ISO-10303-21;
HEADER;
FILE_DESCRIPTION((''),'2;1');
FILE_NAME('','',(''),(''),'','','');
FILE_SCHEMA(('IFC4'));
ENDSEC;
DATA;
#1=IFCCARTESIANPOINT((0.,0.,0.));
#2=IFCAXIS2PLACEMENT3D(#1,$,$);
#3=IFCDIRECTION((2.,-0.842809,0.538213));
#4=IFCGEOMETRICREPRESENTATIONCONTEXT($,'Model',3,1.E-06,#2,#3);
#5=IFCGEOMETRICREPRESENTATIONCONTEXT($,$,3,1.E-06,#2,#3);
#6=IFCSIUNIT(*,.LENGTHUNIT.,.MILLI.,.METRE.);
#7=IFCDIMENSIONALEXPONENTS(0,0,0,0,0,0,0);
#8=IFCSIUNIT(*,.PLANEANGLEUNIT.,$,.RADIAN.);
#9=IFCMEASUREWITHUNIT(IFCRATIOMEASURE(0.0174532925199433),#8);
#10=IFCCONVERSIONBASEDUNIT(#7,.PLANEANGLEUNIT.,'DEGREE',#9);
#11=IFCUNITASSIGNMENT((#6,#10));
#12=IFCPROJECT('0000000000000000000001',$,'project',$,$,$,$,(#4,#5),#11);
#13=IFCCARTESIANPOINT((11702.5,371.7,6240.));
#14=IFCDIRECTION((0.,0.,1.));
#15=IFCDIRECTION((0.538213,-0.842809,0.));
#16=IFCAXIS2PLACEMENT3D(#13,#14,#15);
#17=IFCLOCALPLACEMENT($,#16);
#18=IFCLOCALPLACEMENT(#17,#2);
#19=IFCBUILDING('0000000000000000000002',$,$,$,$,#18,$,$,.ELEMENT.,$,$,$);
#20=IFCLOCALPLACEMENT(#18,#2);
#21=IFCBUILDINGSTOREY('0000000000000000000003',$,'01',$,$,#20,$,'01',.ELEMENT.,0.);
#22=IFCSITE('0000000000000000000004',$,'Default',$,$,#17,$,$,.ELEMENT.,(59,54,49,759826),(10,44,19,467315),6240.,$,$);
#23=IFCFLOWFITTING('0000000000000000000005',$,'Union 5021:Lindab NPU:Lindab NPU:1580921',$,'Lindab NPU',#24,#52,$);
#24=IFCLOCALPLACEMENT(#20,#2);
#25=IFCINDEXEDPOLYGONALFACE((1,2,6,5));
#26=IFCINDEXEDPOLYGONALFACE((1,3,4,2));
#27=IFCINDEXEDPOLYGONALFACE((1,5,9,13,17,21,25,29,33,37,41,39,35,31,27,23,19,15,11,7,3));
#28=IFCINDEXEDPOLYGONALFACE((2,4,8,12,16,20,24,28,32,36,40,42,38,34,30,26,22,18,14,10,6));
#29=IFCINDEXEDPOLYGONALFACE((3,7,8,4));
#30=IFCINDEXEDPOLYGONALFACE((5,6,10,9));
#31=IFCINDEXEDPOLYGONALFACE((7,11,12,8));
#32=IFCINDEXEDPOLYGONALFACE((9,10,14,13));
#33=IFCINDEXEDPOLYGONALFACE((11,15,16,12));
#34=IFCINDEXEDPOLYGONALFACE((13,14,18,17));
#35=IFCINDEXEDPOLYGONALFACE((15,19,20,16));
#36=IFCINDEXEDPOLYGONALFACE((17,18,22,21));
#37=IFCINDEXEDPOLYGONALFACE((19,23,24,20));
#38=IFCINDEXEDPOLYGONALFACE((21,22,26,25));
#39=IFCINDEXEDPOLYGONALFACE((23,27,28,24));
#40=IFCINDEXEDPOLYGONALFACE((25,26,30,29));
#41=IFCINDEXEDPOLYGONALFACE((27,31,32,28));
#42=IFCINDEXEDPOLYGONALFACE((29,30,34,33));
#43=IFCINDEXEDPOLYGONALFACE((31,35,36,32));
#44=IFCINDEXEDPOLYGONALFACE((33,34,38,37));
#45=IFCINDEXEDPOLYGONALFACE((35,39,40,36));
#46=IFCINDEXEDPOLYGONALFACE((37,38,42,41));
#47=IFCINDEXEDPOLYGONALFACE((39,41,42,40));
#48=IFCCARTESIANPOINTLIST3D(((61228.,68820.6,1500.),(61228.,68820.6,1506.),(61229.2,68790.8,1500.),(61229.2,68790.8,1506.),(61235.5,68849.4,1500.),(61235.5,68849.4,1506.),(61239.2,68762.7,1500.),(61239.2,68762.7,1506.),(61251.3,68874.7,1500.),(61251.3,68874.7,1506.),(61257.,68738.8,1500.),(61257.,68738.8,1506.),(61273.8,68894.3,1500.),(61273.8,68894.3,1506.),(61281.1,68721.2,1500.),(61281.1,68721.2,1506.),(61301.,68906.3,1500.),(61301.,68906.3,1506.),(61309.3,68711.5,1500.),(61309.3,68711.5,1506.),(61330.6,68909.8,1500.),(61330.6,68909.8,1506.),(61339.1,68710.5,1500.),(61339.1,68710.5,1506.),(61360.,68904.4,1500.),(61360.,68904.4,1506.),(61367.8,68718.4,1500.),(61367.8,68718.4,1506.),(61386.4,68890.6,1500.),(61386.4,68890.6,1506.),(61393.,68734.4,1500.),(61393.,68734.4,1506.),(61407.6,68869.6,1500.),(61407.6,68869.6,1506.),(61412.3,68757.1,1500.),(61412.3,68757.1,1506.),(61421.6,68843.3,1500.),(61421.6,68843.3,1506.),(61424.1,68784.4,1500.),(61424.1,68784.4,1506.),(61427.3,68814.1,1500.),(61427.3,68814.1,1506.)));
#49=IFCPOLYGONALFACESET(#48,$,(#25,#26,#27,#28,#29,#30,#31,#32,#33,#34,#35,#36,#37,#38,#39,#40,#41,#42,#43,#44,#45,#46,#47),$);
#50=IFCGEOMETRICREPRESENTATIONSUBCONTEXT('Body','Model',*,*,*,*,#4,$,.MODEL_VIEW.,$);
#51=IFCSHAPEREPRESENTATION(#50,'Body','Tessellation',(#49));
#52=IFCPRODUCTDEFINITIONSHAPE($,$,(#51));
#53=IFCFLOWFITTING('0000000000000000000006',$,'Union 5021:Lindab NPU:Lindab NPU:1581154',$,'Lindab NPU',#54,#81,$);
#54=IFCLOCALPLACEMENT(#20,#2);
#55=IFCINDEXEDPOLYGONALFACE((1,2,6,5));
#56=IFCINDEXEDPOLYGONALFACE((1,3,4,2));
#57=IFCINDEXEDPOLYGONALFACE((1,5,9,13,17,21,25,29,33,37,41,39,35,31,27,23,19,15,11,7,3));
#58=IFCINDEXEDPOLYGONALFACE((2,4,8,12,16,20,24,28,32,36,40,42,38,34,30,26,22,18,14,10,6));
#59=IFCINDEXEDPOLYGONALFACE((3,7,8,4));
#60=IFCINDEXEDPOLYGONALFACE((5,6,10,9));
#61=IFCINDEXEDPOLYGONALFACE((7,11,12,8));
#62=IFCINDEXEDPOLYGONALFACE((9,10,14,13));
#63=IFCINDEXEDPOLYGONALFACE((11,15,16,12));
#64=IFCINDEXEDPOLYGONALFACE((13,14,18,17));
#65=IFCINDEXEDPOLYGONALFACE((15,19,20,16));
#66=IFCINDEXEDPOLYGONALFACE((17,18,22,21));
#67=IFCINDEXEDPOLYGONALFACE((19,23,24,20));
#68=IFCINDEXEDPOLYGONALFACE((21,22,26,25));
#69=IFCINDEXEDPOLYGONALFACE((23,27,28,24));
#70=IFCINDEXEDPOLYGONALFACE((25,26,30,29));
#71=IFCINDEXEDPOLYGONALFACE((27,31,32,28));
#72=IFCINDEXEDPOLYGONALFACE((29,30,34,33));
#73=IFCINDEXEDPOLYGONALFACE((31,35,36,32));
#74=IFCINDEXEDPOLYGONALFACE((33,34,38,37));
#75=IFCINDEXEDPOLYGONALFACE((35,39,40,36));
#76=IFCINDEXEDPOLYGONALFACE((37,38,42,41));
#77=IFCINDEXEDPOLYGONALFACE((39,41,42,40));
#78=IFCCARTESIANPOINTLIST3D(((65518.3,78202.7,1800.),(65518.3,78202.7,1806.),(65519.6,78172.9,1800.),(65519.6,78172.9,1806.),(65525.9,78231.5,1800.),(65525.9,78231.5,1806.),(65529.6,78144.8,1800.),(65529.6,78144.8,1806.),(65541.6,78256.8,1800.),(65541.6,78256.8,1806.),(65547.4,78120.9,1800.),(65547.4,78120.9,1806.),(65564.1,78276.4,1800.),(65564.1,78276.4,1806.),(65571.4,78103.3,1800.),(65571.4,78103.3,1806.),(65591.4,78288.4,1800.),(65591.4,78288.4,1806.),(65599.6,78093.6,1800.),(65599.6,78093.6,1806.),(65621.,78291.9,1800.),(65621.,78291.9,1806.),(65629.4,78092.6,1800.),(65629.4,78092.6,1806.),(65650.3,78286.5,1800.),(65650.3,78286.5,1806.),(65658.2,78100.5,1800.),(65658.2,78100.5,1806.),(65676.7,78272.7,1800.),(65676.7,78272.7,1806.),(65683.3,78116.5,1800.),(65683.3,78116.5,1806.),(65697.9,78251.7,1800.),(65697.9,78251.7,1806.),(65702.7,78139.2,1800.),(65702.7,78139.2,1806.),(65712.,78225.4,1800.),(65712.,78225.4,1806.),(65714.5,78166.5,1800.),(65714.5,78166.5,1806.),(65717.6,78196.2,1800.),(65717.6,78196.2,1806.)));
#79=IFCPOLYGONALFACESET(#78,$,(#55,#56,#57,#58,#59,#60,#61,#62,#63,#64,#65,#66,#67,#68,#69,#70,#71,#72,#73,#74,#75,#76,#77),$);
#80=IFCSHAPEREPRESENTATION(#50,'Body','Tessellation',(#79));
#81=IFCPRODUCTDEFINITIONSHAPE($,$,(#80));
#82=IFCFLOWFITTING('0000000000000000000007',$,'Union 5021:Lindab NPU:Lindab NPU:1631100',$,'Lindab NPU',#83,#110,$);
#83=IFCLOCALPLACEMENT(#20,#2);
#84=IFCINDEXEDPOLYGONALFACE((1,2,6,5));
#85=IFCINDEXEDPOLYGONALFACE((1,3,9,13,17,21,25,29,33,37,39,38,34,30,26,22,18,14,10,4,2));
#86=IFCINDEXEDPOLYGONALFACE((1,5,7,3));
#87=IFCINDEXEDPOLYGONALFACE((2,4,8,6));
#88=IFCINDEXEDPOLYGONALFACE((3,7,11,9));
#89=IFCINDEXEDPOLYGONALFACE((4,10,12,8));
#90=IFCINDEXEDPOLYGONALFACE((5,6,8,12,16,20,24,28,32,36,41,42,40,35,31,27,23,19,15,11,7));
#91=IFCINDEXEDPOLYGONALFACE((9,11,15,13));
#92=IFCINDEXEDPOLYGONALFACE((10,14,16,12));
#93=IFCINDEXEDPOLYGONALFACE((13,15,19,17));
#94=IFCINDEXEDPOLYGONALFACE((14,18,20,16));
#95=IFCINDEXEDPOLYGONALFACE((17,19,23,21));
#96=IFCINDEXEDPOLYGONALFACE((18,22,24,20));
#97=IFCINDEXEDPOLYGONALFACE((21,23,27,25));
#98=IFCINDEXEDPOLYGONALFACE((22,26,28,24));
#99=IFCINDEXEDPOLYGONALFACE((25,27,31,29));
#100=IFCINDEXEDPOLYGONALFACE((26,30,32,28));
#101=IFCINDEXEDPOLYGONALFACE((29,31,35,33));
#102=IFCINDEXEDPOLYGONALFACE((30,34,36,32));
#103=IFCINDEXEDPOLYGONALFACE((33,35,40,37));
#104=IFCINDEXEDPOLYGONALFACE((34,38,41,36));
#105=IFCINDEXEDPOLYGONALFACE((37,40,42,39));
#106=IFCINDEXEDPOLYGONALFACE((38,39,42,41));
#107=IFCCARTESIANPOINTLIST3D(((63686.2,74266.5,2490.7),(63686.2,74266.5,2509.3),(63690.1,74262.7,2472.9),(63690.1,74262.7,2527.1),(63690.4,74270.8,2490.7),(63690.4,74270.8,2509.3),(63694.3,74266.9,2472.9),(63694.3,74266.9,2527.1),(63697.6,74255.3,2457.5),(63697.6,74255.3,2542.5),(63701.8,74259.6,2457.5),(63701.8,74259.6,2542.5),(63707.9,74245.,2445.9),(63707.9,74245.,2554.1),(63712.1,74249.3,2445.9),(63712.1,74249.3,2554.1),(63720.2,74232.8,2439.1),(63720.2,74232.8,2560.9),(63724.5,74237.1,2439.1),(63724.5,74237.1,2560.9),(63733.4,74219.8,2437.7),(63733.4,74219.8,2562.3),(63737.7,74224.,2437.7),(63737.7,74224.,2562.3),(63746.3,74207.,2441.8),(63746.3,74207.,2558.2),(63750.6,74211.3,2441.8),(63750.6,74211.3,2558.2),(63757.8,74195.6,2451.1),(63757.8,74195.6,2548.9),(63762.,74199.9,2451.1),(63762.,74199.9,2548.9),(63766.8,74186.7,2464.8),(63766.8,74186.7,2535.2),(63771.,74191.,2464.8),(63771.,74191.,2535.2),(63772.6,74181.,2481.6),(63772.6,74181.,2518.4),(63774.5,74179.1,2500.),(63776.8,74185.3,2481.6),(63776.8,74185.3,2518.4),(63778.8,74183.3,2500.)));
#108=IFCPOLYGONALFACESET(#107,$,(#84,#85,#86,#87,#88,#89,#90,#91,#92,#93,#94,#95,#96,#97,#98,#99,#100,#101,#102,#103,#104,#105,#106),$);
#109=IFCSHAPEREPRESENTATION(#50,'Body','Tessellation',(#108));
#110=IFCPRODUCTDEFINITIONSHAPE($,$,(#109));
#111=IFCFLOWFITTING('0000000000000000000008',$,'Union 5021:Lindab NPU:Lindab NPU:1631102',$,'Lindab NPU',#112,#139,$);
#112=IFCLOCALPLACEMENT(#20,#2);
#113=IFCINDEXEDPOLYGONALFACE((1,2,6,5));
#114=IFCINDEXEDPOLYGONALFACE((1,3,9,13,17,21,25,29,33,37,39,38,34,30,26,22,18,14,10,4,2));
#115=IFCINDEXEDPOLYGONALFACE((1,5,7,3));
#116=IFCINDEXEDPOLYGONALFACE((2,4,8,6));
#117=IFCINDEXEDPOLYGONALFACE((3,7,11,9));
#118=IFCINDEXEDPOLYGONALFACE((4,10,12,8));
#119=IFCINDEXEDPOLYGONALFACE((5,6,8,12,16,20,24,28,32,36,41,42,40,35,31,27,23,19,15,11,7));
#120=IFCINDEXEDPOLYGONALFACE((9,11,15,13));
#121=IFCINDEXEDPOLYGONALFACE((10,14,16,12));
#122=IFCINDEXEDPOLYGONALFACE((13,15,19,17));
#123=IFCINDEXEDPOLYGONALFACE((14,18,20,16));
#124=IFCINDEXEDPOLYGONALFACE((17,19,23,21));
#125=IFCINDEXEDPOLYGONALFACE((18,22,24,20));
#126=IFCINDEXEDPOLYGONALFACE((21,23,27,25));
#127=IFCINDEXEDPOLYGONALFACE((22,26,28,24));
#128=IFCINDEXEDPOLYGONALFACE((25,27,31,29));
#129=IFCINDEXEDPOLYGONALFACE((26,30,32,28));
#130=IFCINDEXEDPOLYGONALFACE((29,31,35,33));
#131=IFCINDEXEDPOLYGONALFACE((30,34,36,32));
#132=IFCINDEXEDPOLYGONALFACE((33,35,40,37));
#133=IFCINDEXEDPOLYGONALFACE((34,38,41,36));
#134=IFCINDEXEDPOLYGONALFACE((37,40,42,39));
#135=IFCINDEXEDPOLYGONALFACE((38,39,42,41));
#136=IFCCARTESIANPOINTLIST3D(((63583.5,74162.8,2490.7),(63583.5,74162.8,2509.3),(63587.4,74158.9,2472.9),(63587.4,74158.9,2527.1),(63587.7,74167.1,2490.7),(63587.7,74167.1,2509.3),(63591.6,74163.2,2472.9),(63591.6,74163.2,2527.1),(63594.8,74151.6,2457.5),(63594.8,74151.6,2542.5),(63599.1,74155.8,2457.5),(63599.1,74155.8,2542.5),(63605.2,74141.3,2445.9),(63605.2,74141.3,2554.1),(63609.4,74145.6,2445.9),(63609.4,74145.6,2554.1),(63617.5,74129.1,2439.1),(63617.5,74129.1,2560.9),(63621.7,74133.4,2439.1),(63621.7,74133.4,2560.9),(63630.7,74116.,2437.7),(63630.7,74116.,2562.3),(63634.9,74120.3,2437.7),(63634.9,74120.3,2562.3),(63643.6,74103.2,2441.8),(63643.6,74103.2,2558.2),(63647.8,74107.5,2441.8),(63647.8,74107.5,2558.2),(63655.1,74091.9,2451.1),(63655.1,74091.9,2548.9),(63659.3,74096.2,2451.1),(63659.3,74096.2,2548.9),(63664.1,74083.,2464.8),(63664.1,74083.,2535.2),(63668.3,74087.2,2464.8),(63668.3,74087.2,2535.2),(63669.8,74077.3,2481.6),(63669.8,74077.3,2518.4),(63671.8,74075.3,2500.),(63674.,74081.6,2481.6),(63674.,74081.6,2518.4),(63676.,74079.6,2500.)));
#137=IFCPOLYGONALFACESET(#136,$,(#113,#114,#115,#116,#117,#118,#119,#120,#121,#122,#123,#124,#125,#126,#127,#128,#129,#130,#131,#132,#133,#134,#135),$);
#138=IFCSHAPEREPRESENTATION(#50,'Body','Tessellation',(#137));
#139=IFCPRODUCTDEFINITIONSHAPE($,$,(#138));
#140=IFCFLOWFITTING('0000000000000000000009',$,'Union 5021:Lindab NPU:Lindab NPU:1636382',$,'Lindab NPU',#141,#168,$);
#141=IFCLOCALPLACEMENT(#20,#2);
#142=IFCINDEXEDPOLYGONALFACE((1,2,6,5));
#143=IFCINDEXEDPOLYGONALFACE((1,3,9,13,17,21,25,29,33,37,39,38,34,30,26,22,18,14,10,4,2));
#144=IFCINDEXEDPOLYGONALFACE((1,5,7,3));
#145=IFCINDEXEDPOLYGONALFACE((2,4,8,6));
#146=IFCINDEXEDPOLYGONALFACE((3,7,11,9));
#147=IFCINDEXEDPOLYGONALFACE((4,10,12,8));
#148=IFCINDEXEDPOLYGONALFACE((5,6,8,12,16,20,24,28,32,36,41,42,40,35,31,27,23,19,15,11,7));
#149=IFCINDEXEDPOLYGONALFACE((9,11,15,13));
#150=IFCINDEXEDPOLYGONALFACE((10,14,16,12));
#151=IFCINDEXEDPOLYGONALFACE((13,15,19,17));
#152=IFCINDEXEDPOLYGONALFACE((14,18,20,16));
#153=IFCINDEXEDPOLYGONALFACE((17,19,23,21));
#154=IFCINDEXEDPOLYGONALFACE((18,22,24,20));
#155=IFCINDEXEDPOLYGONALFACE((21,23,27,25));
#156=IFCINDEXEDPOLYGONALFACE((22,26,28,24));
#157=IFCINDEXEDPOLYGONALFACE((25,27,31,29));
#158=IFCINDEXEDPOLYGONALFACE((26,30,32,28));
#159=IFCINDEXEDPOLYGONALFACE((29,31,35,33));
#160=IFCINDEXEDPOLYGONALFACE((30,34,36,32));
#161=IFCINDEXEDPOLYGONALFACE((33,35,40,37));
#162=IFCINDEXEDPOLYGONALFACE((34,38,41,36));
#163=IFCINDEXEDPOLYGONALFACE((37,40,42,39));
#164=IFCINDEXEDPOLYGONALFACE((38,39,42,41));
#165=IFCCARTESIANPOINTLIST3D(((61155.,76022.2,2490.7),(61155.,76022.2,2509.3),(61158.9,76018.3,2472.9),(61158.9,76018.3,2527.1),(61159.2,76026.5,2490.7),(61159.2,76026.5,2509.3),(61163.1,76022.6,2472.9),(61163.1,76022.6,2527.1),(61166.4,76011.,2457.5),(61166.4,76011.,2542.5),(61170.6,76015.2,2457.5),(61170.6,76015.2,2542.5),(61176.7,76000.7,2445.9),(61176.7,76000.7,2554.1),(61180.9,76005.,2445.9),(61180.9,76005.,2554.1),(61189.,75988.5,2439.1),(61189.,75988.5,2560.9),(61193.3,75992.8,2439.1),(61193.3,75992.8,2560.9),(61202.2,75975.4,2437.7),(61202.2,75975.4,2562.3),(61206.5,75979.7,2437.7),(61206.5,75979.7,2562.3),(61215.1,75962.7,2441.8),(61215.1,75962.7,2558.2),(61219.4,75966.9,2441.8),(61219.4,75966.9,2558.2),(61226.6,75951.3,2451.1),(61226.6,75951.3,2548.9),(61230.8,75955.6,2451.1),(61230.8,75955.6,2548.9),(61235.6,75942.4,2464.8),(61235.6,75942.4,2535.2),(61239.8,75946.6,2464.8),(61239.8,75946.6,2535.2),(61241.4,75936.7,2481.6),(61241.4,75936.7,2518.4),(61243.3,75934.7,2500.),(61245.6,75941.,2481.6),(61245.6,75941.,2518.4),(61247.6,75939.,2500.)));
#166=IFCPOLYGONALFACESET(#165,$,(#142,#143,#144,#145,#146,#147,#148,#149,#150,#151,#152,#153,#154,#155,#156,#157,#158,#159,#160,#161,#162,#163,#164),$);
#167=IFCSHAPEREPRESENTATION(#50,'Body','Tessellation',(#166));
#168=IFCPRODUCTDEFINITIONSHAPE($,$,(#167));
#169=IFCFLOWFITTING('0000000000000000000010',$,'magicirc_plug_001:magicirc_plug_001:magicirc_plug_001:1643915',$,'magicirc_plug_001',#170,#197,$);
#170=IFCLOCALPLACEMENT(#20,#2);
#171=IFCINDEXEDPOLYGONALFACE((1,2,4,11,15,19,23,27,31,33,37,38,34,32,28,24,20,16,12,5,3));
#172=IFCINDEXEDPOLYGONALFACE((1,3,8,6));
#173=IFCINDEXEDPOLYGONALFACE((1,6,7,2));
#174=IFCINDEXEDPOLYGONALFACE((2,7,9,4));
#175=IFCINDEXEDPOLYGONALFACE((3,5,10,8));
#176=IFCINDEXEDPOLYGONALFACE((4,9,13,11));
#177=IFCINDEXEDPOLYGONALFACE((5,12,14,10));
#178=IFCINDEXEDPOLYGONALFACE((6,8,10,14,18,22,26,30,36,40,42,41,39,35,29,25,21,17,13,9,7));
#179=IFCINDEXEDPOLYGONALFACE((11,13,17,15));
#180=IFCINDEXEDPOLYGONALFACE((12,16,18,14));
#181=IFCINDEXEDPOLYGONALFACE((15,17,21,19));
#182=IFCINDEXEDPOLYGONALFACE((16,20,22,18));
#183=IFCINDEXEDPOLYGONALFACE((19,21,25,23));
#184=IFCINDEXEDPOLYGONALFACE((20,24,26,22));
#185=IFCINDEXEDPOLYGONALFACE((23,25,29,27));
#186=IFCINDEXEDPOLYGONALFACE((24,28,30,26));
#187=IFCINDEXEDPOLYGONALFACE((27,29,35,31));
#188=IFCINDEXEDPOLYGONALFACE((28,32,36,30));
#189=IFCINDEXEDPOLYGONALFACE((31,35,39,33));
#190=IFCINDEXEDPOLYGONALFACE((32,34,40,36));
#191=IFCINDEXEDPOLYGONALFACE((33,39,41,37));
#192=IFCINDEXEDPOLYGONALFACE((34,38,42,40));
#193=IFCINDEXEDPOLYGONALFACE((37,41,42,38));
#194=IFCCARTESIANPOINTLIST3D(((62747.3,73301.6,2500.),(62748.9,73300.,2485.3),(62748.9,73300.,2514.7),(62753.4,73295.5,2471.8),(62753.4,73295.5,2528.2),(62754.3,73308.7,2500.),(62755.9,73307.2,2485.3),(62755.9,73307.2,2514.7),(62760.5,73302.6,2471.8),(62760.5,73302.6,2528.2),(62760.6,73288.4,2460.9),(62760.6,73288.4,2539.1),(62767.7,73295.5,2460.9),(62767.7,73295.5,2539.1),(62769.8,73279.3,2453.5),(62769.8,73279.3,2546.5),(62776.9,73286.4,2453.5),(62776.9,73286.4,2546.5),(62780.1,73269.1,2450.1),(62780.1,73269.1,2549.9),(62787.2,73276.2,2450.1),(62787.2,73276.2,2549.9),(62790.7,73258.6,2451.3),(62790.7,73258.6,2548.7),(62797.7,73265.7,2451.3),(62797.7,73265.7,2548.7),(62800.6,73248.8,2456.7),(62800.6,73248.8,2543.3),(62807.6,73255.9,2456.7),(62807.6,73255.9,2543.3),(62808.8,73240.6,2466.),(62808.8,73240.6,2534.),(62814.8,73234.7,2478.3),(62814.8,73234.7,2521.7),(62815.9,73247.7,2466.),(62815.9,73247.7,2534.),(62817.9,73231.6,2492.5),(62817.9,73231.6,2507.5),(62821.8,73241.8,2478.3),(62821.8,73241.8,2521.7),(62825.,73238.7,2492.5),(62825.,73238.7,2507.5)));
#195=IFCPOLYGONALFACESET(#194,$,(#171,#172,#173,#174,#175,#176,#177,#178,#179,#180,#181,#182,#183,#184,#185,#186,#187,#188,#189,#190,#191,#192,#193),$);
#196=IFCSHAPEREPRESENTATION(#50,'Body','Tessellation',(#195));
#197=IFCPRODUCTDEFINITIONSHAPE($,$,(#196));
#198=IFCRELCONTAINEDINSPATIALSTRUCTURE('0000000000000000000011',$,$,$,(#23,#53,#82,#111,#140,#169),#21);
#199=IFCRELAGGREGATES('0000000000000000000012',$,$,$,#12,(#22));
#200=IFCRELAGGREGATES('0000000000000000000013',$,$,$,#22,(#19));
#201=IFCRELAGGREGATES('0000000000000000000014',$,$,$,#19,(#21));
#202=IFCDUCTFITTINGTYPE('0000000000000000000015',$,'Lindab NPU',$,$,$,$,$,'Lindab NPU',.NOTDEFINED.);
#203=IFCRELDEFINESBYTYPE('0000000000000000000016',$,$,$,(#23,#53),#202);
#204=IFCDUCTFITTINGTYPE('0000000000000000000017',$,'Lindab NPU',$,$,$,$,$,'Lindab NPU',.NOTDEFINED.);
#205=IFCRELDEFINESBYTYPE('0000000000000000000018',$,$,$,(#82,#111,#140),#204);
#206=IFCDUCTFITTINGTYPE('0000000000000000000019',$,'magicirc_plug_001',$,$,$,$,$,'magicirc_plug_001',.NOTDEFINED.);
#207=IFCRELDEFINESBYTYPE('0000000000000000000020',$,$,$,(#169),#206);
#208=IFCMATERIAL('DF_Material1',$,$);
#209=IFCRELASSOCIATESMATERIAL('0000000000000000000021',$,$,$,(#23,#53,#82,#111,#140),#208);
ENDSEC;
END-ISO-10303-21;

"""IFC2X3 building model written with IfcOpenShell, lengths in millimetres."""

from ifc_helpers import new_model, entity, si_unit, converted_unit, direction, frame, frame_2d, origin, place, context, subcontext, project, spatial, circle, extrude, source, transform, mapped, material, type_object, type_shapes, element, save


model = new_model("IFC2X3")

# Units and contexts
model_context = context("Model", 3, precision=1e-06, world=origin(), true_north=direction((2.0, -0.842809, 0.538213)))
context_of_model = context(None, 3, precision=1e-06, world=origin(), true_north=direction((2.0, -0.842809, 0.538213)))
body_context = subcontext(model_context, "Body", "Model", "MODEL_VIEW")
ifc_project = project(units=[si_unit("LENGTHUNIT", "METRE", prefix="MILLI"), converted_unit("PLANEANGLEUNIT", "DEGREE", entity("IfcRatioMeasure", 0.0174532925199433), si_unit("PLANEANGLEUNIT", "RADIAN"), dimensions=[0, 0, 0, 0, 0, 0, 0])], contexts=[model_context, context_of_model])

# Site, building, storey
site_placement = place(None, frame((11702.5, 371.7, 6240.0), z_axis=(0.0, 0.0, 1.0), x_axis=(0.538213, -0.842809, 0.0)))
site = spatial("IfcSite", under=ifc_project, at=site_placement, Name="Default", CompositionType="ELEMENT", RefLatitude=(59, 54, 49, 759826), RefLongitude=(10, 44, 19, 467315), RefElevation=6240.0)
building_placement = place(site_placement, origin())
building = spatial("IfcBuilding", under=site, at=building_placement, CompositionType="ELEMENT")
storey_placement = place(building_placement, origin())
storey = spatial("IfcBuildingStorey", under=building, at=storey_placement, Name="01", LongName="01", CompositionType="ELEMENT", Elevation=0.0)

# Flow fittings
ifc_material = material(Name="DF_Material1")
duct_fitting_type_1 = type_object("IfcDuctFittingType", Name="Lindab NPU", ElementType="Lindab NPU", PredefinedType="NOTDEFINED")
shared_shape_1 = source(origin(), body_context, "Body", "SweptSolid", [
    extrude(circle(Radius=100.0, at=frame_2d((0.0, 0.0), x_axis=(1.0, 0.0))), frame((0.0, 0.0, 0.0), z_axis=(1.0, 0.0, 0.0), x_axis=(0.0, 1.0, 0.0)), (0.0, 0.0, 1.0), 6.0),
])
type_shapes(duct_fitting_type_1, [shared_shape_1])
for number, where, z_axis, x_axis, name in (
    (1, (61327.4, 68809.9, 1500.0), (0.710554, -0.703643, 0.0), (0.0, 0.0, 1.0), "Union 5021:Lindab NPU:Lindab NPU:1580921"),
    (2, (65617.7, 78191.9, 1800.0), (0.710554, -0.703643, 0.0), (0.0, 0.0, 1.0), "Union 5021:Lindab NPU:Lindab NPU:1581154"),
):
    element("IfcFlowFitting", number, at=place(storey_placement, frame(where, z_axis=z_axis, x_axis=x_axis)), inside=storey, type_object=duct_fitting_type_1, material=ifc_material, Name=name, ObjectType="Lindab NPU", context=body_context, shape_type="MappedRepresentation", body=[
        mapped(shared_shape_1, transform((0.0, 0.0, 0.0), scale=1.0)),
    ])
duct_fitting_type_2 = type_object("IfcDuctFittingType", Name="Lindab NPU", ElementType="Lindab NPU", PredefinedType="NOTDEFINED")
shared_shape_2 = source(origin(), body_context, "Body", "SweptSolid", [
    extrude(circle(Radius=62.5, at=frame_2d((0.0, 0.0), x_axis=(1.0, 0.0))), frame((0.0, 0.0, 0.0), z_axis=(1.0, 0.0, 0.0), x_axis=(0.0, 1.0, 0.0)), (0.0, 0.0, 1.0), 6.0),
])
type_shapes(duct_fitting_type_2, [shared_shape_2])
for number, where, z_axis, x_axis, name in (
    (3, (63734.3, 74227.3, 2500.0), (0.0, 0.0, 1.0), (-0.703643, -0.710554, 0.0), "Union 5021:Lindab NPU:Lindab NPU:1631100"),
    (4, (63631.6, 74123.6, 2500.0), (0.0, 0.0, 1.0), (-0.703643, -0.710554, 0.0), "Union 5021:Lindab NPU:Lindab NPU:1631102"),
    (5, (61203.1, 75983.0, 2500.0), (0.0, 0.0, 1.0), (-0.703643, -0.710554, 0.0), "Union 5021:Lindab NPU:Lindab NPU:1636382"),
):
    element("IfcFlowFitting", number, at=place(storey_placement, frame(where, z_axis=z_axis, x_axis=x_axis)), inside=storey, type_object=duct_fitting_type_2, material=ifc_material, Name=name, ObjectType="Lindab NPU", context=body_context, shape_type="MappedRepresentation", body=[
        mapped(shared_shape_2, transform((0.0, 0.0, 0.0), scale=1.0)),
    ])

# Flow fitting
duct_fitting_type_3 = type_object("IfcDuctFittingType", Name="magicirc_plug_001", ElementType="magicirc_plug_001", PredefinedType="NOTDEFINED")
shared_shape_3 = source(origin(), body_context, "Body", "SweptSolid", [
    extrude(circle(Radius=50.0, at=frame_2d((0.0, 0.0), x_axis=(1.0, 0.0))), frame((0.0, 0.0, 0.0), z_axis=(1.0, 0.0, 0.0), x_axis=(0.0, 1.0, 0.0)), (0.0, 0.0, 1.0), 10.0),
])
type_shapes(duct_fitting_type_3, [shared_shape_3])
for number, where, z_axis, x_axis, name in (
    (6, (62782.8, 73266.4, 2500.0), (0.0, 0.0, 1.0), (0.703643, 0.710554, 0.0), "magicirc_plug_001:magicirc_plug_001:magicirc_plug_001:1643915"),
):
    element("IfcFlowFitting", number, at=place(storey_placement, frame(where, z_axis=z_axis, x_axis=x_axis)), inside=storey, type_object=duct_fitting_type_3, Name=name, ObjectType="magicirc_plug_001", context=body_context, shape_type="MappedRepresentation", body=[
        mapped(shared_shape_3, transform((0.0, 0.0, 0.0), scale=1.0)),
    ])

save(model, "model.ifc")
